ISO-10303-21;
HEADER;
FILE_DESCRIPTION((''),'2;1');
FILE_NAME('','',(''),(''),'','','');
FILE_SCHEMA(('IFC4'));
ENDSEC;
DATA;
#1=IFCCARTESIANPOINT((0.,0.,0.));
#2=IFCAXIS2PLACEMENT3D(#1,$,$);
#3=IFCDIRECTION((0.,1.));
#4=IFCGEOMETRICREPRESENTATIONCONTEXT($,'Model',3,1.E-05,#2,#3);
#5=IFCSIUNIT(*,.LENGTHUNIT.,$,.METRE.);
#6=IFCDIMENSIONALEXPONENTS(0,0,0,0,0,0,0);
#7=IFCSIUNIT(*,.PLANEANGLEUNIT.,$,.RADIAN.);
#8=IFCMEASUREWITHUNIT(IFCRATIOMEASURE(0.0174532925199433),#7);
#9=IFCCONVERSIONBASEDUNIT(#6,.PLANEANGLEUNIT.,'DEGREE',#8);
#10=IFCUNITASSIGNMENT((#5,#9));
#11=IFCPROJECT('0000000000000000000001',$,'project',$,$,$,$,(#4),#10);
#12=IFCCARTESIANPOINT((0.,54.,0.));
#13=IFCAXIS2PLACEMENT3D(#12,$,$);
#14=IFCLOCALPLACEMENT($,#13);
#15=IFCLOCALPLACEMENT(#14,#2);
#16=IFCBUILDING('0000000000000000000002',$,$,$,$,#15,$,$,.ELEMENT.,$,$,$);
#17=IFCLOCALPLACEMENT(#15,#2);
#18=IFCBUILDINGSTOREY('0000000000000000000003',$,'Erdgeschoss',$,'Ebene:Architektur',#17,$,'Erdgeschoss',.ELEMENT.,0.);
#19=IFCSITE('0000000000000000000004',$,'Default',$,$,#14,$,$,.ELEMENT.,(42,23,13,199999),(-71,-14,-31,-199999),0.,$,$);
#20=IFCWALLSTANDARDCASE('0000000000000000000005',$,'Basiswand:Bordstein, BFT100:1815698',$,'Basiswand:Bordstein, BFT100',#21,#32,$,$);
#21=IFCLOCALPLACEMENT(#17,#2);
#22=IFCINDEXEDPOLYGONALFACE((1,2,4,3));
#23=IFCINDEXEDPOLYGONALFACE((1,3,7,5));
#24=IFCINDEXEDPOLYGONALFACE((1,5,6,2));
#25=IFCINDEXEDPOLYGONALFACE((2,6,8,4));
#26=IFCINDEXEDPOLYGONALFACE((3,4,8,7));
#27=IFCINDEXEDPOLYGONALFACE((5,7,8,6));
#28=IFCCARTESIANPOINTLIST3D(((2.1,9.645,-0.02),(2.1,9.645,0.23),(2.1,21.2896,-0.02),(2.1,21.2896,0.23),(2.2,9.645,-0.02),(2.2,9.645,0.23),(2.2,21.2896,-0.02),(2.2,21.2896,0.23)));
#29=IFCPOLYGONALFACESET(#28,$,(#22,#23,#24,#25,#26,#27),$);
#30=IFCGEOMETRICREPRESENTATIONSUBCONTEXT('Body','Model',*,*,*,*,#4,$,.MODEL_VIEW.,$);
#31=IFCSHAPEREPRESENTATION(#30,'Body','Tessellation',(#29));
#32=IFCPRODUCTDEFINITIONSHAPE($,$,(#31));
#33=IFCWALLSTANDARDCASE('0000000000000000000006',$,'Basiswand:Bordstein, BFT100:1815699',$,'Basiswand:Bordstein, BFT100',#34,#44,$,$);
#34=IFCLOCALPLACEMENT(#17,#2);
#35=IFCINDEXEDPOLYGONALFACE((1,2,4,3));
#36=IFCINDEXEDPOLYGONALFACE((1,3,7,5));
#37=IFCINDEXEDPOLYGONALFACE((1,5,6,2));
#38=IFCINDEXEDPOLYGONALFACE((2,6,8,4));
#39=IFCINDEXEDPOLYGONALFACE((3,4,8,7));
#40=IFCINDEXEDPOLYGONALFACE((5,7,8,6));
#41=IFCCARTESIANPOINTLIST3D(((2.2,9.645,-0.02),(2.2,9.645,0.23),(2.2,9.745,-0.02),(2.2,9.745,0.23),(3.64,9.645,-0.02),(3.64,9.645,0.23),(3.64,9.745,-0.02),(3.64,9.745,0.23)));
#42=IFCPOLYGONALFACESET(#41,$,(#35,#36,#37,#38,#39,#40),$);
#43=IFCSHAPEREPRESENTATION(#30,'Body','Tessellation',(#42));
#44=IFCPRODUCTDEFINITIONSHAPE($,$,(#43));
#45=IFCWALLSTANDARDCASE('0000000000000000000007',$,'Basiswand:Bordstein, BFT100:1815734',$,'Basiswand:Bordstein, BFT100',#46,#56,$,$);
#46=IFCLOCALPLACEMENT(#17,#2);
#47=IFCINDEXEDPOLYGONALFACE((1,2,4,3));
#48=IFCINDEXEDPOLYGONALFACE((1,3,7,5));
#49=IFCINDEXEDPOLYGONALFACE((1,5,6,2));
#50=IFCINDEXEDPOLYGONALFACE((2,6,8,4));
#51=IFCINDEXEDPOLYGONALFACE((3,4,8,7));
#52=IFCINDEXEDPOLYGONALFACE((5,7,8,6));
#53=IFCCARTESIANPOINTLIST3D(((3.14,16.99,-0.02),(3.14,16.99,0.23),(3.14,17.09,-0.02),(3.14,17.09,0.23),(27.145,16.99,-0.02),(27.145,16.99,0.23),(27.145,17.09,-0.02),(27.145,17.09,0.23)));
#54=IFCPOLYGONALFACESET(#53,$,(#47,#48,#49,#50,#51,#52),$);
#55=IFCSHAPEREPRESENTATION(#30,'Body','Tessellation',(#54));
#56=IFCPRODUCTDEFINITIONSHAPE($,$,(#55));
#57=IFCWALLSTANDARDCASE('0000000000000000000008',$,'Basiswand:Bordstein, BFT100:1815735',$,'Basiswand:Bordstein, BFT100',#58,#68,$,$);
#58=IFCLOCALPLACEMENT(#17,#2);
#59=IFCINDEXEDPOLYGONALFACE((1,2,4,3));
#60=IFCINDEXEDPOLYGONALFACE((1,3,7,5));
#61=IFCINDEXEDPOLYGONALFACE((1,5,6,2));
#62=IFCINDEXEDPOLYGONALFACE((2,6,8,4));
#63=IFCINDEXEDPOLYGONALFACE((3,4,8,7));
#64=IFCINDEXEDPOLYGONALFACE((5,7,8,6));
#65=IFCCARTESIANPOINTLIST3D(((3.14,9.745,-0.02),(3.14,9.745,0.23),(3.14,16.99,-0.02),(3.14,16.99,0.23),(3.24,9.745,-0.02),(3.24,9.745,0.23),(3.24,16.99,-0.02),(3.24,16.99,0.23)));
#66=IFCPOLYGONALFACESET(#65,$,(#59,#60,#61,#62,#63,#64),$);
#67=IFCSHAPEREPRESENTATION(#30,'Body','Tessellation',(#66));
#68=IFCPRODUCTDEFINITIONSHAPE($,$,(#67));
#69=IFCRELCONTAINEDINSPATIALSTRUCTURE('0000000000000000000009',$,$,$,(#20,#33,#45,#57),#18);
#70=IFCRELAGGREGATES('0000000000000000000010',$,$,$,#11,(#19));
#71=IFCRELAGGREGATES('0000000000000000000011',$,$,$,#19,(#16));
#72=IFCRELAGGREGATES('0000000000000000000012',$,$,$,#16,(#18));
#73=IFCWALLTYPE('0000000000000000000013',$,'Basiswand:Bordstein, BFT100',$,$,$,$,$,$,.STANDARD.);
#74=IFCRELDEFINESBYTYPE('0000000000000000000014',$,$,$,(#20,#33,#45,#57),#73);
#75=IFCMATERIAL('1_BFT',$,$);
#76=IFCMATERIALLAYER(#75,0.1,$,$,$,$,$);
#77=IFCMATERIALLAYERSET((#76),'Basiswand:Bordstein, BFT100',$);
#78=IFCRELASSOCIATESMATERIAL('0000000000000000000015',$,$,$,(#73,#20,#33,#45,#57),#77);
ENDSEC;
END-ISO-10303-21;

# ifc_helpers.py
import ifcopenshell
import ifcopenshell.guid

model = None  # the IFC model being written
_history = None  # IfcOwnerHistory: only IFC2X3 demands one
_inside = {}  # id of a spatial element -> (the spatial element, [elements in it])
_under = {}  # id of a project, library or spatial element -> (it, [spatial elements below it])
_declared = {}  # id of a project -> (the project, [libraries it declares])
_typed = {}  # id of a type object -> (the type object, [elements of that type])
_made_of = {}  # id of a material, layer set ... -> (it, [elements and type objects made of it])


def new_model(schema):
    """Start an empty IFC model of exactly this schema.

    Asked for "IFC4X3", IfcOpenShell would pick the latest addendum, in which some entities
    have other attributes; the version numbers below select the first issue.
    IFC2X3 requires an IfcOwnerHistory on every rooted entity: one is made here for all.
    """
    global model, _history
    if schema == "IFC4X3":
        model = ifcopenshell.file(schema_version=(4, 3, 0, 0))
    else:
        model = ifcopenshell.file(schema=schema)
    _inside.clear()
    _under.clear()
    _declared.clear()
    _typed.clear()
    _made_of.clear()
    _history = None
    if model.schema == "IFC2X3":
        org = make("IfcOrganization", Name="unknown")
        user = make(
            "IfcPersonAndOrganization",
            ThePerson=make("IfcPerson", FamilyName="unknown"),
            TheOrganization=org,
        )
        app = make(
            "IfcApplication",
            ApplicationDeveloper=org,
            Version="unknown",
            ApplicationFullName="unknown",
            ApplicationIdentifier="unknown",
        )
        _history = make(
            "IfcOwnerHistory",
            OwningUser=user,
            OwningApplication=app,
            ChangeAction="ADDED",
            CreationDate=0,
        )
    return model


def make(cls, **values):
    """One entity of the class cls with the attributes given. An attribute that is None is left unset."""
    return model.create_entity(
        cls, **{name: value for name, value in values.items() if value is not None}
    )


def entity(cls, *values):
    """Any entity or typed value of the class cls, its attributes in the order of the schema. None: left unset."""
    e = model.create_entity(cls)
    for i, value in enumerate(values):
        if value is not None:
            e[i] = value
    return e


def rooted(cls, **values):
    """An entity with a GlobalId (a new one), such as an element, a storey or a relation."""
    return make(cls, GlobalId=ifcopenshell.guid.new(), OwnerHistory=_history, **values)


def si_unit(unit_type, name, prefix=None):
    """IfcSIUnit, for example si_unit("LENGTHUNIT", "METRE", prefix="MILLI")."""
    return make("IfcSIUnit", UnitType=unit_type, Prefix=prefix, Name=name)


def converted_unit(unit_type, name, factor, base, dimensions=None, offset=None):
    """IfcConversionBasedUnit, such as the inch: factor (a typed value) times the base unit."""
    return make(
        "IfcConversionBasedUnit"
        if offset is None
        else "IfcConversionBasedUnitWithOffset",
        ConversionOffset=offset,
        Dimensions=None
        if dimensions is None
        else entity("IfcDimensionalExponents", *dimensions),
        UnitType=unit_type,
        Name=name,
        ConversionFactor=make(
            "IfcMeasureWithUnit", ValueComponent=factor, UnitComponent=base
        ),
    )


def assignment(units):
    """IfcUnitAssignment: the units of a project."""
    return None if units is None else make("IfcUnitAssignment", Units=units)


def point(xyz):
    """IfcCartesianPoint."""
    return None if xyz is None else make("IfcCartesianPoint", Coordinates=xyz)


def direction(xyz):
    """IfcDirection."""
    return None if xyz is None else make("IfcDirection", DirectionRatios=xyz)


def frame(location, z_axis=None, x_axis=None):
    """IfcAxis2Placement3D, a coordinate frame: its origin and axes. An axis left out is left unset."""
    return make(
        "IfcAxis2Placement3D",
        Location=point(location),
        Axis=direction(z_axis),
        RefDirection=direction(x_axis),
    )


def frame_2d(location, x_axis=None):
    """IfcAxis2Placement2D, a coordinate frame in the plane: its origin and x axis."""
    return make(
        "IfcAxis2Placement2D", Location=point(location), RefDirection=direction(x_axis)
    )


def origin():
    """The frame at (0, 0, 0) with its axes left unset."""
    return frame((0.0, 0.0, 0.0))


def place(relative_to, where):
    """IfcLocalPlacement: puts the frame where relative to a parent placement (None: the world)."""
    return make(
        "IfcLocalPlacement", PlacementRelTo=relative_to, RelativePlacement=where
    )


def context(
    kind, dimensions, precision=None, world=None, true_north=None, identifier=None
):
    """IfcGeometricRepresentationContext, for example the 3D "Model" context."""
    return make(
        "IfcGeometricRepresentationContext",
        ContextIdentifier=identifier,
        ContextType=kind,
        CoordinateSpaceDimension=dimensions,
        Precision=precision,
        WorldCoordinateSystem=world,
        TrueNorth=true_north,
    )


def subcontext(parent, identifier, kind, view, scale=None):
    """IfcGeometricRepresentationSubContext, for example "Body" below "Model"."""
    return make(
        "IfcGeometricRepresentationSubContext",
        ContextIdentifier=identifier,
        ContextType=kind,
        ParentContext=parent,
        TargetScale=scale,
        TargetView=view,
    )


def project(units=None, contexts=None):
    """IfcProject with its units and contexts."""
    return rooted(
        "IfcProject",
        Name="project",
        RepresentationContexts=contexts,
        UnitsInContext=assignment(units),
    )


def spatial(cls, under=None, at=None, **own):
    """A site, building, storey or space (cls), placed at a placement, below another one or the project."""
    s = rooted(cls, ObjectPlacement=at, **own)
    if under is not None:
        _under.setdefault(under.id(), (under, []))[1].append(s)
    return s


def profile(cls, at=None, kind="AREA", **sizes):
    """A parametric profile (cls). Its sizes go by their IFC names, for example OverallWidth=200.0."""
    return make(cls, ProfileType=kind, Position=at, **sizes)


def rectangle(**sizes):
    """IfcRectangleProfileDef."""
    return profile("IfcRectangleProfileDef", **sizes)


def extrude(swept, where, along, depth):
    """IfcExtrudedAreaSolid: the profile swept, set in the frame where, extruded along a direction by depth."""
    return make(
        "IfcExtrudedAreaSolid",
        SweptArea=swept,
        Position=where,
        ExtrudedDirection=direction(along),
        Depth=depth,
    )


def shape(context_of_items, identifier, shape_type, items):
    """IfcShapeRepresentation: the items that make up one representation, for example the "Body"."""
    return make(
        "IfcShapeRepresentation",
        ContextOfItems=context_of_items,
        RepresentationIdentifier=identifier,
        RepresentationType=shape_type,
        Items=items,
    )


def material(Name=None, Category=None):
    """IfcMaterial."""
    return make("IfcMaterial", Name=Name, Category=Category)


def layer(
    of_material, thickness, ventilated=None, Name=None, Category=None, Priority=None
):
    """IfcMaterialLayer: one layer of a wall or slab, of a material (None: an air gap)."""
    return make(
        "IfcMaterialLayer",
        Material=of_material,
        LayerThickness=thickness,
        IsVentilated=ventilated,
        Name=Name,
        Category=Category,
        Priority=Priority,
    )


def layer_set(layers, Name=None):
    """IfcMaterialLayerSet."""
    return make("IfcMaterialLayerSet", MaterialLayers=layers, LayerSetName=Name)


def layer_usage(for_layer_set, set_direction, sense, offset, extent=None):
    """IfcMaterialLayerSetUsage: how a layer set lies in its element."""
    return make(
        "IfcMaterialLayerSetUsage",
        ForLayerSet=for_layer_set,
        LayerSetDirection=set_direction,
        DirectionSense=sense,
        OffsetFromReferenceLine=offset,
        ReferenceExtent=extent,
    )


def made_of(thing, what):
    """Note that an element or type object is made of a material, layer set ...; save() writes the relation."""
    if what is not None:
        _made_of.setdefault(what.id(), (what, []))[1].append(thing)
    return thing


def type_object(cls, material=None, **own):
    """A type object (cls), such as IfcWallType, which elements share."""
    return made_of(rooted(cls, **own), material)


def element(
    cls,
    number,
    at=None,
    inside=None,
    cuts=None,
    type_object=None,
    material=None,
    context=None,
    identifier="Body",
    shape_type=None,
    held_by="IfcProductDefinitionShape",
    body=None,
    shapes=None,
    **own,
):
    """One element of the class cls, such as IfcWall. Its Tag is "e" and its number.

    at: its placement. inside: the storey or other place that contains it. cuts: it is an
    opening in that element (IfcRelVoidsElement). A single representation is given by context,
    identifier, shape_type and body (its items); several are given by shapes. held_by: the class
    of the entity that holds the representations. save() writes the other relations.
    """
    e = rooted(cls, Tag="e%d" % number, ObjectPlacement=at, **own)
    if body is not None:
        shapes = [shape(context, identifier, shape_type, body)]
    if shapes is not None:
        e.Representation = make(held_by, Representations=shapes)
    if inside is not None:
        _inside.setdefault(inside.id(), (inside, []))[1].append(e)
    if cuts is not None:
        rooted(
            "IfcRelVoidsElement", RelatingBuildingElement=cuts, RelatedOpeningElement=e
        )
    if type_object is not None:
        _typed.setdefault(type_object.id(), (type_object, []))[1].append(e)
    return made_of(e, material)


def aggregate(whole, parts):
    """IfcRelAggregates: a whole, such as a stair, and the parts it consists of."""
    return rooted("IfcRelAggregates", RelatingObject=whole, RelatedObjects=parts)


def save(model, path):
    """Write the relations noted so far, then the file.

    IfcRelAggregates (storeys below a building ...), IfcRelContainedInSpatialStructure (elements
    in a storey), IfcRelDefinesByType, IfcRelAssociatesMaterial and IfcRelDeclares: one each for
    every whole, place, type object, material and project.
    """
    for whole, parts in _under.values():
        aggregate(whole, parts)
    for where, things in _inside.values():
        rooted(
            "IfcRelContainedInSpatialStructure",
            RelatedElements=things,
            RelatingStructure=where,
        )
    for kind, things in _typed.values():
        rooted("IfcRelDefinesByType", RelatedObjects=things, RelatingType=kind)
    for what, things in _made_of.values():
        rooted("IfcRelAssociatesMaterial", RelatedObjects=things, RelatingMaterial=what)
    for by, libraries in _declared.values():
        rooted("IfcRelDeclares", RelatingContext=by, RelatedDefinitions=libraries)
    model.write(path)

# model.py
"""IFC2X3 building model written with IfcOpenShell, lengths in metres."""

from ifc_helpers import new_model, entity, si_unit, converted_unit, direction, frame, frame_2d, origin, place, context, subcontext, project, spatial, rectangle, extrude, material, layer, layer_set, layer_usage, type_object, element, save


model = new_model("IFC2X3")

# Units and contexts
model_context = context("Model", 3, precision=1e-05, world=origin(), true_north=direction((0.0, 1.0)))
body_context = subcontext(model_context, "Body", "Model", "MODEL_VIEW")
ifc_project = project(units=[si_unit("LENGTHUNIT", "METRE"), converted_unit("PLANEANGLEUNIT", "DEGREE", entity("IfcRatioMeasure", 0.0174532925199433), si_unit("PLANEANGLEUNIT", "RADIAN"), dimensions=[0, 0, 0, 0, 0, 0, 0])], contexts=[model_context])

# Site, building, storey
site_placement = place(None, frame((0.0, 54.0, 0.0)))
site = spatial("IfcSite", under=ifc_project, at=site_placement, Name="Default", CompositionType="ELEMENT", RefLatitude=(42, 23, 13, 199999), RefLongitude=(-71, -14, -31, -199999), RefElevation=0.0)
building_placement = place(site_placement, origin())
building = spatial("IfcBuilding", under=site, at=building_placement, CompositionType="ELEMENT")
storey_placement = place(building_placement, origin())
storey = spatial("IfcBuildingStorey", under=building, at=storey_placement, Name="Erdgeschoss", ObjectType="Ebene:Architektur", LongName="Erdgeschoss", CompositionType="ELEMENT", Elevation=0.0)

# Walls
ifc_material_1 = material(Name="1_BFT")
ifc_layer_1 = layer(ifc_material_1, 0.1)
ifc_layer_set_1 = layer_set([ifc_layer_1], Name="Basiswand:Bordstein, BFT100")
ifc_layer_usage_1 = layer_usage(ifc_layer_set_1, "AXIS2", "NEGATIVE", 0.05)
wall_type = type_object("IfcWallType", Name="Basiswand:Bordstein, BFT100", PredefinedType="STANDARD", material=ifc_layer_set_1)
wall_1_placement = place(storey_placement, frame((2.15, 21.2896, -0.02), z_axis=(0.0, 0.0, 1.0), x_axis=(0.0, -1.0, 0.0)))
element("IfcWallStandardCase", 1, at=wall_1_placement, inside=storey, type_object=wall_type, material=ifc_layer_usage_1, Name="Basiswand:Bordstein, BFT100:1815698", ObjectType="Basiswand:Bordstein, BFT100", context=body_context, shape_type="SweptSolid", body=[
    extrude(rectangle(XDim=11.6446, YDim=0.1, at=frame_2d((5.8223, 0.0), x_axis=(-1.0, 0.0))), origin(), (0.0, 0.0, 1.0), 0.25),
])
ifc_layer_usage_2 = layer_usage(ifc_layer_set_1, "AXIS2", "NEGATIVE", 0.05)
wall_2_placement = place(storey_placement, frame((2.2, 9.695, -0.02)))
element("IfcWallStandardCase", 2, at=wall_2_placement, inside=storey, type_object=wall_type, material=ifc_layer_usage_2, Name="Basiswand:Bordstein, BFT100:1815699", ObjectType="Basiswand:Bordstein, BFT100", context=body_context, shape_type="SweptSolid", body=[
    extrude(rectangle(XDim=1.44, YDim=0.1, at=frame_2d((0.72, 0.0), x_axis=(-1.0, 0.0))), origin(), (0.0, 0.0, 1.0), 0.25),
])
ifc_layer_usage_3 = layer_usage(ifc_layer_set_1, "AXIS2", "NEGATIVE", 0.05)
wall_3_placement = place(storey_placement, frame((3.14, 17.04, -0.02)))
element("IfcWallStandardCase", 3, at=wall_3_placement, inside=storey, type_object=wall_type, material=ifc_layer_usage_3, Name="Basiswand:Bordstein, BFT100:1815734", ObjectType="Basiswand:Bordstein, BFT100", context=body_context, shape_type="SweptSolid", body=[
    extrude(rectangle(XDim=24.005, YDim=0.1, at=frame_2d((12.0025, 0.0), x_axis=(-1.0, 0.0))), origin(), (0.0, 0.0, 1.0), 0.25),
])
ifc_layer_usage_4 = layer_usage(ifc_layer_set_1, "AXIS2", "POSITIVE", -0.05)
wall_4_placement = place(storey_placement, frame((3.19, 16.99, -0.02), z_axis=(0.0, 0.0, 1.0), x_axis=(0.0, -1.0, 0.0)))
element("IfcWallStandardCase", 4, at=wall_4_placement, inside=storey, type_object=wall_type, material=ifc_layer_usage_4, Name="Basiswand:Bordstein, BFT100:1815735", ObjectType="Basiswand:Bordstein, BFT100", context=body_context, shape_type="SweptSolid", body=[
    extrude(rectangle(XDim=7.245, YDim=0.1, at=frame_2d((3.6225, 0.0), x_axis=(-1.0, 0.0))), origin(), (0.0, 0.0, 1.0), 0.25),
])

save(model, "model.ifc")
